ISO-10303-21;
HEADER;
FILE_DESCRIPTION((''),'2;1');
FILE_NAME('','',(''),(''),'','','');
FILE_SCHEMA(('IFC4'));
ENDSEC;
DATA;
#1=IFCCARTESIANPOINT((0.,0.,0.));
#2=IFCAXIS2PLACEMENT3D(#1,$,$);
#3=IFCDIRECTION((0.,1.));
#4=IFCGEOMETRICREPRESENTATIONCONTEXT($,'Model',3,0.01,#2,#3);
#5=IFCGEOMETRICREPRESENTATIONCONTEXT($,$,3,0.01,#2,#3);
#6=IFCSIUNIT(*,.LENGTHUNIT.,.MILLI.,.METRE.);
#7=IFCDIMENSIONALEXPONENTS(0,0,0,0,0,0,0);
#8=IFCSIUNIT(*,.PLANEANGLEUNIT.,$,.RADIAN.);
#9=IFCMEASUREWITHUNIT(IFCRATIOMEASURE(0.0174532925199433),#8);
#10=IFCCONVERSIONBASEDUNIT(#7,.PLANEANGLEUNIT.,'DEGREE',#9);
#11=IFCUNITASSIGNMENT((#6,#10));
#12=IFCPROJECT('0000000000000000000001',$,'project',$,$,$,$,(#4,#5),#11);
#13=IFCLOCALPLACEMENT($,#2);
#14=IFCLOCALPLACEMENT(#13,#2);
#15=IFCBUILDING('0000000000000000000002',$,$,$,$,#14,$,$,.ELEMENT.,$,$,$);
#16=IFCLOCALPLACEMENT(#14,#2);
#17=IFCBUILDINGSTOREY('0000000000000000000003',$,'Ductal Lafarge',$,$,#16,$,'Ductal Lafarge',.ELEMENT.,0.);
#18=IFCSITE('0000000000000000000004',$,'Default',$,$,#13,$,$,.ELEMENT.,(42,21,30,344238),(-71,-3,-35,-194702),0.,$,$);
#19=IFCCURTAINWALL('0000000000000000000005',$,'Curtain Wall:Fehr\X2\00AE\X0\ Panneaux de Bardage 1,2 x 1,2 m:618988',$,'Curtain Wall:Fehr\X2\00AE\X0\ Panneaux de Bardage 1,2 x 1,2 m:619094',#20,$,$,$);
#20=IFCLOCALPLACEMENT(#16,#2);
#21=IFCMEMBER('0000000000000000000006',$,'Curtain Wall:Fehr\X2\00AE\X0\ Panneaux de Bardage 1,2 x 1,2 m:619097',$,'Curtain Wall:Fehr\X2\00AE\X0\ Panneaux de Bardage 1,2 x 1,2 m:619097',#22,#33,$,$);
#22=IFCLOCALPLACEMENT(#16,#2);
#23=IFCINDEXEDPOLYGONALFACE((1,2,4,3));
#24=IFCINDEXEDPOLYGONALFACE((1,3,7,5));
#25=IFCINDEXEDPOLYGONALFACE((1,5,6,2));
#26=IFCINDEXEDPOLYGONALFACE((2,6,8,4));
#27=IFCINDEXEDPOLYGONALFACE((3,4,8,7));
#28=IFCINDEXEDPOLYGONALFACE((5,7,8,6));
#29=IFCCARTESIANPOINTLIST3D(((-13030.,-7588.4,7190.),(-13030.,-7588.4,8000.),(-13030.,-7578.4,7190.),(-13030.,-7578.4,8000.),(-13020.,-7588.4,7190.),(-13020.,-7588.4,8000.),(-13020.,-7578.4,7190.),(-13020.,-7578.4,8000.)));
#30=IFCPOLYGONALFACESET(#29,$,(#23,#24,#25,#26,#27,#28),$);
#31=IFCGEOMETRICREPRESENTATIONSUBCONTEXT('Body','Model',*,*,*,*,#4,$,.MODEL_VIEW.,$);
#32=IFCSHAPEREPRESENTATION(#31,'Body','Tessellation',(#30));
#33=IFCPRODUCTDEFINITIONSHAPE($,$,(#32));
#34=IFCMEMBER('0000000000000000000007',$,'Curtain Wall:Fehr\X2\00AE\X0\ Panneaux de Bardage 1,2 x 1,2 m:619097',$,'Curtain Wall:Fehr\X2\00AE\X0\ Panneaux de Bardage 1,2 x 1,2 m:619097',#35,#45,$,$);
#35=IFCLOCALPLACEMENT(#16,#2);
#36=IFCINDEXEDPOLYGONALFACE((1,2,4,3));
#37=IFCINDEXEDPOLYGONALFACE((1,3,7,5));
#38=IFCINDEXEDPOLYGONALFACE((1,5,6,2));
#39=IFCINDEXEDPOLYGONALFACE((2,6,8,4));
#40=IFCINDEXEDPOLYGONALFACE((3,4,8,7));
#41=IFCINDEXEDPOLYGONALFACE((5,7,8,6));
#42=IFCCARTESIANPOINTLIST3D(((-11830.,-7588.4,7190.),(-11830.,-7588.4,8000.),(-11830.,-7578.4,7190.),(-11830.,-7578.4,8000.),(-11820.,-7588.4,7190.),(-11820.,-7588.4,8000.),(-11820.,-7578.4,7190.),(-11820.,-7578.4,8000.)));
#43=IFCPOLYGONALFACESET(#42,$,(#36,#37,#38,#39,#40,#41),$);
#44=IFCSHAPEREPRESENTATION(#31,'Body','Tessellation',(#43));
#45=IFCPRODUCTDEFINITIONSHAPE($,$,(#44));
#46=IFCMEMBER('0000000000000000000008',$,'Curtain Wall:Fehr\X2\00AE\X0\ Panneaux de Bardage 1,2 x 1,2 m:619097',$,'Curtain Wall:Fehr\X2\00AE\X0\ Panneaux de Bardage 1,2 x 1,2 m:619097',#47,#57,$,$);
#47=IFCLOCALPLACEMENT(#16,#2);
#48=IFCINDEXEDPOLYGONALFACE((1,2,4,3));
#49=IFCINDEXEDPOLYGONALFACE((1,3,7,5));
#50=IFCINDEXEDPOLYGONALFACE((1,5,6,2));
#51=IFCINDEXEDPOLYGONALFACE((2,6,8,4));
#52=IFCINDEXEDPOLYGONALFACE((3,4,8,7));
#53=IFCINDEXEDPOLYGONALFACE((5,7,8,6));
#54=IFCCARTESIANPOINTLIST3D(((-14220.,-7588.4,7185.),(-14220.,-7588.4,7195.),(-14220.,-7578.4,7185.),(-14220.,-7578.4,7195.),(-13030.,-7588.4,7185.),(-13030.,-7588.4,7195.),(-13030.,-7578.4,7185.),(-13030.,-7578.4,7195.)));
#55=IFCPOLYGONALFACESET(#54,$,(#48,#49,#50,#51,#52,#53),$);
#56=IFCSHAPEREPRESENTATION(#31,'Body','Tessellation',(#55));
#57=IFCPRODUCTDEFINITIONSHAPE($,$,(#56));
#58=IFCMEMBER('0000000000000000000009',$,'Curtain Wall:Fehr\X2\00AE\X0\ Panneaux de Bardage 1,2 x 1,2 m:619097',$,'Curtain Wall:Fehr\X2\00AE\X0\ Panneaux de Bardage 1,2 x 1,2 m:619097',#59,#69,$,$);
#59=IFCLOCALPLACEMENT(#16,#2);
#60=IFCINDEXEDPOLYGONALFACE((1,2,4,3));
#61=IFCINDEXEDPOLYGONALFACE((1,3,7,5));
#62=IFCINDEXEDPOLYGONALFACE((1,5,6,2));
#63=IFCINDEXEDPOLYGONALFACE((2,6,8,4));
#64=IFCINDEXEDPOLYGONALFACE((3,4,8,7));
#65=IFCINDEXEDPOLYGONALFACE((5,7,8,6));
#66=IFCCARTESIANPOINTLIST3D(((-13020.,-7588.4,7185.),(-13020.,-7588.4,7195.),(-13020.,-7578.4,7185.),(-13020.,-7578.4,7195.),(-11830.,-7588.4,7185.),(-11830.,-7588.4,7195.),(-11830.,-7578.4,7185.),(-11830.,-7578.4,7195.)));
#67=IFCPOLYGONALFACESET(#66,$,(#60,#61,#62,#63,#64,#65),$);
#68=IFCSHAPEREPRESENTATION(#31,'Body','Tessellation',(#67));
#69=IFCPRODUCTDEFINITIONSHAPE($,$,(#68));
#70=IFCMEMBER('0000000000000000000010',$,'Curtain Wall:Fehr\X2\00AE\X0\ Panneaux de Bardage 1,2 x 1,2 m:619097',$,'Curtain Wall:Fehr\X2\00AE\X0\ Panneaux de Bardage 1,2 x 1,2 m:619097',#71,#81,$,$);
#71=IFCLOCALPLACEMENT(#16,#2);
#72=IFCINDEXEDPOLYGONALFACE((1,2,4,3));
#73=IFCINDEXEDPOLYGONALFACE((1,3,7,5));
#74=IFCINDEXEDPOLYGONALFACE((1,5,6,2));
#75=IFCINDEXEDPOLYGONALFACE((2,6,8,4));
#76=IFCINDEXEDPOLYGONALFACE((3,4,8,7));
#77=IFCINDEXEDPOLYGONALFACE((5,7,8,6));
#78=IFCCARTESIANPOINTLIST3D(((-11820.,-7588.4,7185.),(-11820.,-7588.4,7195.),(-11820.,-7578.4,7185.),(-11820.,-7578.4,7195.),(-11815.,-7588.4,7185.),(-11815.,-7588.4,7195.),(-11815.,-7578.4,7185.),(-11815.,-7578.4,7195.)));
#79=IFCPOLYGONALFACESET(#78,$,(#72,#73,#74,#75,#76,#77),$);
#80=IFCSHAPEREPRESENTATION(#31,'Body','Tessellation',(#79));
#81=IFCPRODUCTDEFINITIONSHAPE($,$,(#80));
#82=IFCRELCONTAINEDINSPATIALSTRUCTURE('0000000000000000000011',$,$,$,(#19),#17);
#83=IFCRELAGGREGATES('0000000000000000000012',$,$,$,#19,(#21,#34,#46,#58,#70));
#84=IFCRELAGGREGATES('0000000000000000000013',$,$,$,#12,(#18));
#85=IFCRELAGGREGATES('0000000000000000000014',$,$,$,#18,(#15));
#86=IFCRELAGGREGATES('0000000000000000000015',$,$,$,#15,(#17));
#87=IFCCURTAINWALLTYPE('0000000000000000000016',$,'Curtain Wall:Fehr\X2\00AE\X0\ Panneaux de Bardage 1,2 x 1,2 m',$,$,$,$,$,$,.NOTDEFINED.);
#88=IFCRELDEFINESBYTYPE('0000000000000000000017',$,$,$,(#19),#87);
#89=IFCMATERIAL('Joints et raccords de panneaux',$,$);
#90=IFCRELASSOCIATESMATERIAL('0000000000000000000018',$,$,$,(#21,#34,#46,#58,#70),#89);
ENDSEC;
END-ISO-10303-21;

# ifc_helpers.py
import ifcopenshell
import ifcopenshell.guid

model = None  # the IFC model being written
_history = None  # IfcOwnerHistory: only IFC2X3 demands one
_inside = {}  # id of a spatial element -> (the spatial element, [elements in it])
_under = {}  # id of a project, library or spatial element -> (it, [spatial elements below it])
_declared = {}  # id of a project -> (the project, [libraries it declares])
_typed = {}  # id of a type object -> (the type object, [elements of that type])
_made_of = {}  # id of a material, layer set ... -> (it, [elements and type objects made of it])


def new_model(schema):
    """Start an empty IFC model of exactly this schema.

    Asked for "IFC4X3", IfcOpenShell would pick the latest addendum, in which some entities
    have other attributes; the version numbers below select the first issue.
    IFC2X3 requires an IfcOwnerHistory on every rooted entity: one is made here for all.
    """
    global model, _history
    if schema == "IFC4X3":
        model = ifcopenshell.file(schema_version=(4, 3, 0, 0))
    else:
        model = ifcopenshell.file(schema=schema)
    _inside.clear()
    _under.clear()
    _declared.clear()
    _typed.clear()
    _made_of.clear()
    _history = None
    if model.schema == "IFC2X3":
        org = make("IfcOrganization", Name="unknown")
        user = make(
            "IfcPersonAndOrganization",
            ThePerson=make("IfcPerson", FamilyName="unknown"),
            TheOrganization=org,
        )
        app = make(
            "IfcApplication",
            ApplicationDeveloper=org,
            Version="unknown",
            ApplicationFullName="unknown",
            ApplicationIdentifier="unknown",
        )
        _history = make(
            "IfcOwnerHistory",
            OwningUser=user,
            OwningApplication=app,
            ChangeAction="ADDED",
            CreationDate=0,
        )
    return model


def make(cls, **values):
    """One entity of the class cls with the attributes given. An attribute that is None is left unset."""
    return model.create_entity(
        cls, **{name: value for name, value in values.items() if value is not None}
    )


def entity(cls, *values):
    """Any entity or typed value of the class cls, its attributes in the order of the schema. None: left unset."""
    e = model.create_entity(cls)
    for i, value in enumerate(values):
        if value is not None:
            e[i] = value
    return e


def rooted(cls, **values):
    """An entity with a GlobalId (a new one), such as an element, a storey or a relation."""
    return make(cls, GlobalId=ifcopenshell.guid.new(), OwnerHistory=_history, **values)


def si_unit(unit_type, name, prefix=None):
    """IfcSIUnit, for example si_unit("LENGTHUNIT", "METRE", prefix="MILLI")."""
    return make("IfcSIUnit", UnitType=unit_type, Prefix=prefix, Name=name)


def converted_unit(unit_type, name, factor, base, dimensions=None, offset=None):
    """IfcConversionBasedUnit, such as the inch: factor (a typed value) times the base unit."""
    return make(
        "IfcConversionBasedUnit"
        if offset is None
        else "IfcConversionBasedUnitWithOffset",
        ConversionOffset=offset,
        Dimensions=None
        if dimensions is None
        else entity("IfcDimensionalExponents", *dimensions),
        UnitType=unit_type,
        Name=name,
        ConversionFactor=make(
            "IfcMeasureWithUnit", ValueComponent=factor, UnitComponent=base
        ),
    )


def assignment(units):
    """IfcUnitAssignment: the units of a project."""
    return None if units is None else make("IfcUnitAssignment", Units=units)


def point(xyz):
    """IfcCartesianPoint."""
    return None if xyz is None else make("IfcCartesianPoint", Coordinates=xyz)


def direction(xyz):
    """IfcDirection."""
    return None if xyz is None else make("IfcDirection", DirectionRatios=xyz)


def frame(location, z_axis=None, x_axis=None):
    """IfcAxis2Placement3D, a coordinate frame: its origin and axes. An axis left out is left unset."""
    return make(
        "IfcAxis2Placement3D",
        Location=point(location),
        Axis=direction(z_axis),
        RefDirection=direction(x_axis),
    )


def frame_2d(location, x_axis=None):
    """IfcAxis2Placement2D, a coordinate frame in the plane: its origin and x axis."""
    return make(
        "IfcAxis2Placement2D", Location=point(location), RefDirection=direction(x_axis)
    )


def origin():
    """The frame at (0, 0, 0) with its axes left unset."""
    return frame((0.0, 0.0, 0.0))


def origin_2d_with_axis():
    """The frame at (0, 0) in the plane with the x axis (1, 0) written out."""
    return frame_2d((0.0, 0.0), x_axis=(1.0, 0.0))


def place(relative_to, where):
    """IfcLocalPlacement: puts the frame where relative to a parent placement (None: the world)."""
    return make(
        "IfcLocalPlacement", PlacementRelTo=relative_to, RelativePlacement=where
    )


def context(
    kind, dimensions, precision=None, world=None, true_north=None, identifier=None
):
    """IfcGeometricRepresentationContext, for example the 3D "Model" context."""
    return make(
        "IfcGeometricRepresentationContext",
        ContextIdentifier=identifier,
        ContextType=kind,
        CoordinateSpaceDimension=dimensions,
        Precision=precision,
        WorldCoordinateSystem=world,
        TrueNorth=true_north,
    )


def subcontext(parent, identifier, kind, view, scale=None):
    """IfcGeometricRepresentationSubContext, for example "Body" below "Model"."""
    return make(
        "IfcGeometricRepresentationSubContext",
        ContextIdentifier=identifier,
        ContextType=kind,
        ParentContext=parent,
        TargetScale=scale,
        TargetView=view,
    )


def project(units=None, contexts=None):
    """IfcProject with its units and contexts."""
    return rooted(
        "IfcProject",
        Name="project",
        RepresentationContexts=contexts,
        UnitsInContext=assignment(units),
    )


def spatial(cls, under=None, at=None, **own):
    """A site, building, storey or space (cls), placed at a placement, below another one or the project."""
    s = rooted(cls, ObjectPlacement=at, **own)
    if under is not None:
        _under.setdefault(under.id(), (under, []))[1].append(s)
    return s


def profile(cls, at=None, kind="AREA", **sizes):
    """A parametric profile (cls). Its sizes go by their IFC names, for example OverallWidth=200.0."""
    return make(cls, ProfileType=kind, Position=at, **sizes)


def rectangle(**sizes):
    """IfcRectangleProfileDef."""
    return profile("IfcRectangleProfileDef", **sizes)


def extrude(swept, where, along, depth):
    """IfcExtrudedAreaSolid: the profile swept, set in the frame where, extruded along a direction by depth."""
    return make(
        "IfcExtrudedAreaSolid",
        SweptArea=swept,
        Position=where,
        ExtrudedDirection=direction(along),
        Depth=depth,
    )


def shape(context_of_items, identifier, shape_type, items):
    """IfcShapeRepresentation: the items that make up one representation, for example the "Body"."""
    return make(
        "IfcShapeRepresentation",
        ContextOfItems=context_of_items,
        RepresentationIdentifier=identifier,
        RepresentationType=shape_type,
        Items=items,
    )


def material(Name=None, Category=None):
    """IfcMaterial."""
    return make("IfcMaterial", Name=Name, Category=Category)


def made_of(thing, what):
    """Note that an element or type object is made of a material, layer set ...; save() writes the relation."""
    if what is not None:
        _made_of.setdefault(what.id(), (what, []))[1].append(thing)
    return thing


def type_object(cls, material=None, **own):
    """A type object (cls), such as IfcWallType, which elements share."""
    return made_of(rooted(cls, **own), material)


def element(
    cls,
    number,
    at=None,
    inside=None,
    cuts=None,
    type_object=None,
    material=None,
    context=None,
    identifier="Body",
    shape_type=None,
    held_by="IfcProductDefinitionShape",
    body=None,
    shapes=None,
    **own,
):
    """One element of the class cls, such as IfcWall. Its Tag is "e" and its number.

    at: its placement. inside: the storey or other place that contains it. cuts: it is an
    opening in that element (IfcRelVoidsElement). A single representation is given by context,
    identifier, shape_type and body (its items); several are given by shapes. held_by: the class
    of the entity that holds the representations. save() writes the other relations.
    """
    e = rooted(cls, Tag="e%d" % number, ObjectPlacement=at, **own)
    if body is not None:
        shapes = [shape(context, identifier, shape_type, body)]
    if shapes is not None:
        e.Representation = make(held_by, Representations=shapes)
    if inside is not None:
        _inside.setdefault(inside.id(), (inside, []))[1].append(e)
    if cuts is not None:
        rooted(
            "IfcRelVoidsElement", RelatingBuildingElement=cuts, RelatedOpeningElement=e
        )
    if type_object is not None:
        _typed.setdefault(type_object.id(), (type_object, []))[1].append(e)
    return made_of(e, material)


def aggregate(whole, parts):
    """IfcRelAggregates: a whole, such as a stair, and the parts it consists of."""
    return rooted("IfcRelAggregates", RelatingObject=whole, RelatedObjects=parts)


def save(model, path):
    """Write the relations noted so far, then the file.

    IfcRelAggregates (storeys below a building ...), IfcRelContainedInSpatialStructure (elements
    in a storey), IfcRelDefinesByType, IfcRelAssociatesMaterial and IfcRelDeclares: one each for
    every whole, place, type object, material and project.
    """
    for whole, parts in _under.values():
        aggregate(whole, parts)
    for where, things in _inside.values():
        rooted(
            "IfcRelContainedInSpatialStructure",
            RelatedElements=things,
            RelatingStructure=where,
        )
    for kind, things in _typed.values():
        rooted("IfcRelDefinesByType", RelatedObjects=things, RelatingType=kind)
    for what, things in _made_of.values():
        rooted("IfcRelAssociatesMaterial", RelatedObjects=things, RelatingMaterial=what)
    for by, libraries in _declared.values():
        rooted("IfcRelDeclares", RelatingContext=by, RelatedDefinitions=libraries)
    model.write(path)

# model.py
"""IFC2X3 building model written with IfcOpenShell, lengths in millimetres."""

from ifc_helpers import new_model, entity, si_unit, converted_unit, direction, frame, frame_2d, origin, origin_2d_with_axis, place, context, subcontext, project, spatial, rectangle, extrude, material, type_object, element, aggregate, save


model = new_model("IFC2X3")

# Units and contexts
model_context = context("Model", 3, precision=0.01, world=origin(), true_north=direction((0.0, 1.0)))
context_of_model = context(None, 3, precision=0.01, world=origin(), true_north=direction((0.0, 1.0)))
body_context = subcontext(model_context, "Body", "Model", "MODEL_VIEW")
ifc_project = project(units=[si_unit("LENGTHUNIT", "METRE", prefix="MILLI"), converted_unit("PLANEANGLEUNIT", "DEGREE", entity("IfcRatioMeasure", 0.0174532925199433), si_unit("PLANEANGLEUNIT", "RADIAN"), dimensions=[0, 0, 0, 0, 0, 0, 0])], contexts=[model_context, context_of_model])

# Site, building, storey
site_placement = place(None, origin())
site = spatial("IfcSite", under=ifc_project, at=site_placement, Name="Default", CompositionType="ELEMENT", RefLatitude=(42, 21, 30, 344238), RefLongitude=(-71, -3, -35, -194702), RefElevation=0.0)
building_placement = place(site_placement, origin())
building = spatial("IfcBuilding", under=site, at=building_placement, CompositionType="ELEMENT")
storey_placement = place(building_placement, origin())
storey = spatial("IfcBuildingStorey", under=building, at=storey_placement, Name="Ductal Lafarge", LongName="Ductal Lafarge", CompositionType="ELEMENT", Elevation=0.0)

# Curtain wall, members
curtain_wall_type = type_object("IfcCurtainWallType", Name="Curtain Wall:Fehr® Panneaux de Bardage 1,2 x 1,2 m", PredefinedType="NOTDEFINED")
curtain_wall_placement = place(storey_placement, origin())
curtain_wall = element("IfcCurtainWall", 1, at=curtain_wall_placement, inside=storey, type_object=curtain_wall_type, Name="Curtain Wall:Fehr® Panneaux de Bardage 1,2 x 1,2 m:618988", ObjectType="Curtain Wall:Fehr® Panneaux de Bardage 1,2 x 1,2 m:619094")
ifc_material = material(Name="Joints et raccords de panneaux")
member_1_placement = place(curtain_wall_placement, frame((-13030.0, -7588.4, 7190.0)))
member_1 = element("IfcMember", 2, at=member_1_placement, material=ifc_material, Name="Curtain Wall:Fehr® Panneaux de Bardage 1,2 x 1,2 m:619097", ObjectType="Curtain Wall:Fehr® Panneaux de Bardage 1,2 x 1,2 m:619097", context=body_context, shape_type="SweptSolid", body=[
    extrude(rectangle(XDim=10.0, YDim=10.0, at=frame_2d((0.0, 0.0), x_axis=(1.0, 0.0))), frame((5.0, 5.0, 0.0), z_axis=(0.0, 0.0, 1.0), x_axis=(0.0, 1.0, 0.0)), (0.0, 0.0, 1.0), 810.0),
])
member_2_placement = place(curtain_wall_placement, frame((-11830.0, -7588.4, 7190.0)))
member_2 = element("IfcMember", 3, at=member_2_placement, material=ifc_material, Name="Curtain Wall:Fehr® Panneaux de Bardage 1,2 x 1,2 m:619097", ObjectType="Curtain Wall:Fehr® Panneaux de Bardage 1,2 x 1,2 m:619097", context=body_context, shape_type="SweptSolid", body=[
    extrude(rectangle(XDim=10.0, YDim=10.0, at=frame_2d((0.0, 0.0), x_axis=(1.0, 0.0))), frame((5.0, 5.0, 0.0), z_axis=(0.0, 0.0, 1.0), x_axis=(0.0, 1.0, 0.0)), (0.0, 0.0, 1.0), 810.0),
])
member_3_placement = place(curtain_wall_placement, frame((-14220.0, -7588.4, 7185.0)))
member_3 = element("IfcMember", 4, at=member_3_placement, material=ifc_material, Name="Curtain Wall:Fehr® Panneaux de Bardage 1,2 x 1,2 m:619097", ObjectType="Curtain Wall:Fehr® Panneaux de Bardage 1,2 x 1,2 m:619097", context=body_context, shape_type="SweptSolid", body=[
    extrude(rectangle(XDim=1190.0, YDim=10.0, at=frame_2d((0.0, 0.0), x_axis=(1.0, 0.0))), frame((595.0, 5.0, 0.0), z_axis=(0.0, 0.0, 1.0), x_axis=(-1.0, 0.0, 0.0)), (0.0, 0.0, 1.0), 10.0),
])
member_4_placement = place(curtain_wall_placement, frame((-13020.0, -7588.4, 7185.0)))
member_4 = element("IfcMember", 5, at=member_4_placement, material=ifc_material, Name="Curtain Wall:Fehr® Panneaux de Bardage 1,2 x 1,2 m:619097", ObjectType="Curtain Wall:Fehr® Panneaux de Bardage 1,2 x 1,2 m:619097", context=body_context, shape_type="SweptSolid", body=[
    extrude(rectangle(XDim=1190.0, YDim=10.0, at=frame_2d((0.0, 0.0), x_axis=(1.0, 0.0))), frame((595.0, 5.0, 0.0), z_axis=(0.0, 0.0, 1.0), x_axis=(-1.0, 0.0, 0.0)), (0.0, 0.0, 1.0), 10.0),
])
member_5_placement = place(curtain_wall_placement, frame((-11820.0, -7588.4, 7185.0)))
member_5 = element("IfcMember", 6, at=member_5_placement, material=ifc_material, Name="Curtain Wall:Fehr® Panneaux de Bardage 1,2 x 1,2 m:619097", ObjectType="Curtain Wall:Fehr® Panneaux de Bardage 1,2 x 1,2 m:619097", context=body_context, shape_type="SweptSolid", body=[
    extrude(rectangle(XDim=5.0, YDim=10.0, at=origin_2d_with_axis()), frame((2.5, 5.0, 0.0), z_axis=(0.0, 0.0, 1.0), x_axis=(-1.0, 0.0, 0.0)), (0.0, 0.0, 1.0), 10.0),
])
aggregate(curtain_wall, [member_1, member_2, member_3, member_4, member_5])

save(model, "model.ifc")
